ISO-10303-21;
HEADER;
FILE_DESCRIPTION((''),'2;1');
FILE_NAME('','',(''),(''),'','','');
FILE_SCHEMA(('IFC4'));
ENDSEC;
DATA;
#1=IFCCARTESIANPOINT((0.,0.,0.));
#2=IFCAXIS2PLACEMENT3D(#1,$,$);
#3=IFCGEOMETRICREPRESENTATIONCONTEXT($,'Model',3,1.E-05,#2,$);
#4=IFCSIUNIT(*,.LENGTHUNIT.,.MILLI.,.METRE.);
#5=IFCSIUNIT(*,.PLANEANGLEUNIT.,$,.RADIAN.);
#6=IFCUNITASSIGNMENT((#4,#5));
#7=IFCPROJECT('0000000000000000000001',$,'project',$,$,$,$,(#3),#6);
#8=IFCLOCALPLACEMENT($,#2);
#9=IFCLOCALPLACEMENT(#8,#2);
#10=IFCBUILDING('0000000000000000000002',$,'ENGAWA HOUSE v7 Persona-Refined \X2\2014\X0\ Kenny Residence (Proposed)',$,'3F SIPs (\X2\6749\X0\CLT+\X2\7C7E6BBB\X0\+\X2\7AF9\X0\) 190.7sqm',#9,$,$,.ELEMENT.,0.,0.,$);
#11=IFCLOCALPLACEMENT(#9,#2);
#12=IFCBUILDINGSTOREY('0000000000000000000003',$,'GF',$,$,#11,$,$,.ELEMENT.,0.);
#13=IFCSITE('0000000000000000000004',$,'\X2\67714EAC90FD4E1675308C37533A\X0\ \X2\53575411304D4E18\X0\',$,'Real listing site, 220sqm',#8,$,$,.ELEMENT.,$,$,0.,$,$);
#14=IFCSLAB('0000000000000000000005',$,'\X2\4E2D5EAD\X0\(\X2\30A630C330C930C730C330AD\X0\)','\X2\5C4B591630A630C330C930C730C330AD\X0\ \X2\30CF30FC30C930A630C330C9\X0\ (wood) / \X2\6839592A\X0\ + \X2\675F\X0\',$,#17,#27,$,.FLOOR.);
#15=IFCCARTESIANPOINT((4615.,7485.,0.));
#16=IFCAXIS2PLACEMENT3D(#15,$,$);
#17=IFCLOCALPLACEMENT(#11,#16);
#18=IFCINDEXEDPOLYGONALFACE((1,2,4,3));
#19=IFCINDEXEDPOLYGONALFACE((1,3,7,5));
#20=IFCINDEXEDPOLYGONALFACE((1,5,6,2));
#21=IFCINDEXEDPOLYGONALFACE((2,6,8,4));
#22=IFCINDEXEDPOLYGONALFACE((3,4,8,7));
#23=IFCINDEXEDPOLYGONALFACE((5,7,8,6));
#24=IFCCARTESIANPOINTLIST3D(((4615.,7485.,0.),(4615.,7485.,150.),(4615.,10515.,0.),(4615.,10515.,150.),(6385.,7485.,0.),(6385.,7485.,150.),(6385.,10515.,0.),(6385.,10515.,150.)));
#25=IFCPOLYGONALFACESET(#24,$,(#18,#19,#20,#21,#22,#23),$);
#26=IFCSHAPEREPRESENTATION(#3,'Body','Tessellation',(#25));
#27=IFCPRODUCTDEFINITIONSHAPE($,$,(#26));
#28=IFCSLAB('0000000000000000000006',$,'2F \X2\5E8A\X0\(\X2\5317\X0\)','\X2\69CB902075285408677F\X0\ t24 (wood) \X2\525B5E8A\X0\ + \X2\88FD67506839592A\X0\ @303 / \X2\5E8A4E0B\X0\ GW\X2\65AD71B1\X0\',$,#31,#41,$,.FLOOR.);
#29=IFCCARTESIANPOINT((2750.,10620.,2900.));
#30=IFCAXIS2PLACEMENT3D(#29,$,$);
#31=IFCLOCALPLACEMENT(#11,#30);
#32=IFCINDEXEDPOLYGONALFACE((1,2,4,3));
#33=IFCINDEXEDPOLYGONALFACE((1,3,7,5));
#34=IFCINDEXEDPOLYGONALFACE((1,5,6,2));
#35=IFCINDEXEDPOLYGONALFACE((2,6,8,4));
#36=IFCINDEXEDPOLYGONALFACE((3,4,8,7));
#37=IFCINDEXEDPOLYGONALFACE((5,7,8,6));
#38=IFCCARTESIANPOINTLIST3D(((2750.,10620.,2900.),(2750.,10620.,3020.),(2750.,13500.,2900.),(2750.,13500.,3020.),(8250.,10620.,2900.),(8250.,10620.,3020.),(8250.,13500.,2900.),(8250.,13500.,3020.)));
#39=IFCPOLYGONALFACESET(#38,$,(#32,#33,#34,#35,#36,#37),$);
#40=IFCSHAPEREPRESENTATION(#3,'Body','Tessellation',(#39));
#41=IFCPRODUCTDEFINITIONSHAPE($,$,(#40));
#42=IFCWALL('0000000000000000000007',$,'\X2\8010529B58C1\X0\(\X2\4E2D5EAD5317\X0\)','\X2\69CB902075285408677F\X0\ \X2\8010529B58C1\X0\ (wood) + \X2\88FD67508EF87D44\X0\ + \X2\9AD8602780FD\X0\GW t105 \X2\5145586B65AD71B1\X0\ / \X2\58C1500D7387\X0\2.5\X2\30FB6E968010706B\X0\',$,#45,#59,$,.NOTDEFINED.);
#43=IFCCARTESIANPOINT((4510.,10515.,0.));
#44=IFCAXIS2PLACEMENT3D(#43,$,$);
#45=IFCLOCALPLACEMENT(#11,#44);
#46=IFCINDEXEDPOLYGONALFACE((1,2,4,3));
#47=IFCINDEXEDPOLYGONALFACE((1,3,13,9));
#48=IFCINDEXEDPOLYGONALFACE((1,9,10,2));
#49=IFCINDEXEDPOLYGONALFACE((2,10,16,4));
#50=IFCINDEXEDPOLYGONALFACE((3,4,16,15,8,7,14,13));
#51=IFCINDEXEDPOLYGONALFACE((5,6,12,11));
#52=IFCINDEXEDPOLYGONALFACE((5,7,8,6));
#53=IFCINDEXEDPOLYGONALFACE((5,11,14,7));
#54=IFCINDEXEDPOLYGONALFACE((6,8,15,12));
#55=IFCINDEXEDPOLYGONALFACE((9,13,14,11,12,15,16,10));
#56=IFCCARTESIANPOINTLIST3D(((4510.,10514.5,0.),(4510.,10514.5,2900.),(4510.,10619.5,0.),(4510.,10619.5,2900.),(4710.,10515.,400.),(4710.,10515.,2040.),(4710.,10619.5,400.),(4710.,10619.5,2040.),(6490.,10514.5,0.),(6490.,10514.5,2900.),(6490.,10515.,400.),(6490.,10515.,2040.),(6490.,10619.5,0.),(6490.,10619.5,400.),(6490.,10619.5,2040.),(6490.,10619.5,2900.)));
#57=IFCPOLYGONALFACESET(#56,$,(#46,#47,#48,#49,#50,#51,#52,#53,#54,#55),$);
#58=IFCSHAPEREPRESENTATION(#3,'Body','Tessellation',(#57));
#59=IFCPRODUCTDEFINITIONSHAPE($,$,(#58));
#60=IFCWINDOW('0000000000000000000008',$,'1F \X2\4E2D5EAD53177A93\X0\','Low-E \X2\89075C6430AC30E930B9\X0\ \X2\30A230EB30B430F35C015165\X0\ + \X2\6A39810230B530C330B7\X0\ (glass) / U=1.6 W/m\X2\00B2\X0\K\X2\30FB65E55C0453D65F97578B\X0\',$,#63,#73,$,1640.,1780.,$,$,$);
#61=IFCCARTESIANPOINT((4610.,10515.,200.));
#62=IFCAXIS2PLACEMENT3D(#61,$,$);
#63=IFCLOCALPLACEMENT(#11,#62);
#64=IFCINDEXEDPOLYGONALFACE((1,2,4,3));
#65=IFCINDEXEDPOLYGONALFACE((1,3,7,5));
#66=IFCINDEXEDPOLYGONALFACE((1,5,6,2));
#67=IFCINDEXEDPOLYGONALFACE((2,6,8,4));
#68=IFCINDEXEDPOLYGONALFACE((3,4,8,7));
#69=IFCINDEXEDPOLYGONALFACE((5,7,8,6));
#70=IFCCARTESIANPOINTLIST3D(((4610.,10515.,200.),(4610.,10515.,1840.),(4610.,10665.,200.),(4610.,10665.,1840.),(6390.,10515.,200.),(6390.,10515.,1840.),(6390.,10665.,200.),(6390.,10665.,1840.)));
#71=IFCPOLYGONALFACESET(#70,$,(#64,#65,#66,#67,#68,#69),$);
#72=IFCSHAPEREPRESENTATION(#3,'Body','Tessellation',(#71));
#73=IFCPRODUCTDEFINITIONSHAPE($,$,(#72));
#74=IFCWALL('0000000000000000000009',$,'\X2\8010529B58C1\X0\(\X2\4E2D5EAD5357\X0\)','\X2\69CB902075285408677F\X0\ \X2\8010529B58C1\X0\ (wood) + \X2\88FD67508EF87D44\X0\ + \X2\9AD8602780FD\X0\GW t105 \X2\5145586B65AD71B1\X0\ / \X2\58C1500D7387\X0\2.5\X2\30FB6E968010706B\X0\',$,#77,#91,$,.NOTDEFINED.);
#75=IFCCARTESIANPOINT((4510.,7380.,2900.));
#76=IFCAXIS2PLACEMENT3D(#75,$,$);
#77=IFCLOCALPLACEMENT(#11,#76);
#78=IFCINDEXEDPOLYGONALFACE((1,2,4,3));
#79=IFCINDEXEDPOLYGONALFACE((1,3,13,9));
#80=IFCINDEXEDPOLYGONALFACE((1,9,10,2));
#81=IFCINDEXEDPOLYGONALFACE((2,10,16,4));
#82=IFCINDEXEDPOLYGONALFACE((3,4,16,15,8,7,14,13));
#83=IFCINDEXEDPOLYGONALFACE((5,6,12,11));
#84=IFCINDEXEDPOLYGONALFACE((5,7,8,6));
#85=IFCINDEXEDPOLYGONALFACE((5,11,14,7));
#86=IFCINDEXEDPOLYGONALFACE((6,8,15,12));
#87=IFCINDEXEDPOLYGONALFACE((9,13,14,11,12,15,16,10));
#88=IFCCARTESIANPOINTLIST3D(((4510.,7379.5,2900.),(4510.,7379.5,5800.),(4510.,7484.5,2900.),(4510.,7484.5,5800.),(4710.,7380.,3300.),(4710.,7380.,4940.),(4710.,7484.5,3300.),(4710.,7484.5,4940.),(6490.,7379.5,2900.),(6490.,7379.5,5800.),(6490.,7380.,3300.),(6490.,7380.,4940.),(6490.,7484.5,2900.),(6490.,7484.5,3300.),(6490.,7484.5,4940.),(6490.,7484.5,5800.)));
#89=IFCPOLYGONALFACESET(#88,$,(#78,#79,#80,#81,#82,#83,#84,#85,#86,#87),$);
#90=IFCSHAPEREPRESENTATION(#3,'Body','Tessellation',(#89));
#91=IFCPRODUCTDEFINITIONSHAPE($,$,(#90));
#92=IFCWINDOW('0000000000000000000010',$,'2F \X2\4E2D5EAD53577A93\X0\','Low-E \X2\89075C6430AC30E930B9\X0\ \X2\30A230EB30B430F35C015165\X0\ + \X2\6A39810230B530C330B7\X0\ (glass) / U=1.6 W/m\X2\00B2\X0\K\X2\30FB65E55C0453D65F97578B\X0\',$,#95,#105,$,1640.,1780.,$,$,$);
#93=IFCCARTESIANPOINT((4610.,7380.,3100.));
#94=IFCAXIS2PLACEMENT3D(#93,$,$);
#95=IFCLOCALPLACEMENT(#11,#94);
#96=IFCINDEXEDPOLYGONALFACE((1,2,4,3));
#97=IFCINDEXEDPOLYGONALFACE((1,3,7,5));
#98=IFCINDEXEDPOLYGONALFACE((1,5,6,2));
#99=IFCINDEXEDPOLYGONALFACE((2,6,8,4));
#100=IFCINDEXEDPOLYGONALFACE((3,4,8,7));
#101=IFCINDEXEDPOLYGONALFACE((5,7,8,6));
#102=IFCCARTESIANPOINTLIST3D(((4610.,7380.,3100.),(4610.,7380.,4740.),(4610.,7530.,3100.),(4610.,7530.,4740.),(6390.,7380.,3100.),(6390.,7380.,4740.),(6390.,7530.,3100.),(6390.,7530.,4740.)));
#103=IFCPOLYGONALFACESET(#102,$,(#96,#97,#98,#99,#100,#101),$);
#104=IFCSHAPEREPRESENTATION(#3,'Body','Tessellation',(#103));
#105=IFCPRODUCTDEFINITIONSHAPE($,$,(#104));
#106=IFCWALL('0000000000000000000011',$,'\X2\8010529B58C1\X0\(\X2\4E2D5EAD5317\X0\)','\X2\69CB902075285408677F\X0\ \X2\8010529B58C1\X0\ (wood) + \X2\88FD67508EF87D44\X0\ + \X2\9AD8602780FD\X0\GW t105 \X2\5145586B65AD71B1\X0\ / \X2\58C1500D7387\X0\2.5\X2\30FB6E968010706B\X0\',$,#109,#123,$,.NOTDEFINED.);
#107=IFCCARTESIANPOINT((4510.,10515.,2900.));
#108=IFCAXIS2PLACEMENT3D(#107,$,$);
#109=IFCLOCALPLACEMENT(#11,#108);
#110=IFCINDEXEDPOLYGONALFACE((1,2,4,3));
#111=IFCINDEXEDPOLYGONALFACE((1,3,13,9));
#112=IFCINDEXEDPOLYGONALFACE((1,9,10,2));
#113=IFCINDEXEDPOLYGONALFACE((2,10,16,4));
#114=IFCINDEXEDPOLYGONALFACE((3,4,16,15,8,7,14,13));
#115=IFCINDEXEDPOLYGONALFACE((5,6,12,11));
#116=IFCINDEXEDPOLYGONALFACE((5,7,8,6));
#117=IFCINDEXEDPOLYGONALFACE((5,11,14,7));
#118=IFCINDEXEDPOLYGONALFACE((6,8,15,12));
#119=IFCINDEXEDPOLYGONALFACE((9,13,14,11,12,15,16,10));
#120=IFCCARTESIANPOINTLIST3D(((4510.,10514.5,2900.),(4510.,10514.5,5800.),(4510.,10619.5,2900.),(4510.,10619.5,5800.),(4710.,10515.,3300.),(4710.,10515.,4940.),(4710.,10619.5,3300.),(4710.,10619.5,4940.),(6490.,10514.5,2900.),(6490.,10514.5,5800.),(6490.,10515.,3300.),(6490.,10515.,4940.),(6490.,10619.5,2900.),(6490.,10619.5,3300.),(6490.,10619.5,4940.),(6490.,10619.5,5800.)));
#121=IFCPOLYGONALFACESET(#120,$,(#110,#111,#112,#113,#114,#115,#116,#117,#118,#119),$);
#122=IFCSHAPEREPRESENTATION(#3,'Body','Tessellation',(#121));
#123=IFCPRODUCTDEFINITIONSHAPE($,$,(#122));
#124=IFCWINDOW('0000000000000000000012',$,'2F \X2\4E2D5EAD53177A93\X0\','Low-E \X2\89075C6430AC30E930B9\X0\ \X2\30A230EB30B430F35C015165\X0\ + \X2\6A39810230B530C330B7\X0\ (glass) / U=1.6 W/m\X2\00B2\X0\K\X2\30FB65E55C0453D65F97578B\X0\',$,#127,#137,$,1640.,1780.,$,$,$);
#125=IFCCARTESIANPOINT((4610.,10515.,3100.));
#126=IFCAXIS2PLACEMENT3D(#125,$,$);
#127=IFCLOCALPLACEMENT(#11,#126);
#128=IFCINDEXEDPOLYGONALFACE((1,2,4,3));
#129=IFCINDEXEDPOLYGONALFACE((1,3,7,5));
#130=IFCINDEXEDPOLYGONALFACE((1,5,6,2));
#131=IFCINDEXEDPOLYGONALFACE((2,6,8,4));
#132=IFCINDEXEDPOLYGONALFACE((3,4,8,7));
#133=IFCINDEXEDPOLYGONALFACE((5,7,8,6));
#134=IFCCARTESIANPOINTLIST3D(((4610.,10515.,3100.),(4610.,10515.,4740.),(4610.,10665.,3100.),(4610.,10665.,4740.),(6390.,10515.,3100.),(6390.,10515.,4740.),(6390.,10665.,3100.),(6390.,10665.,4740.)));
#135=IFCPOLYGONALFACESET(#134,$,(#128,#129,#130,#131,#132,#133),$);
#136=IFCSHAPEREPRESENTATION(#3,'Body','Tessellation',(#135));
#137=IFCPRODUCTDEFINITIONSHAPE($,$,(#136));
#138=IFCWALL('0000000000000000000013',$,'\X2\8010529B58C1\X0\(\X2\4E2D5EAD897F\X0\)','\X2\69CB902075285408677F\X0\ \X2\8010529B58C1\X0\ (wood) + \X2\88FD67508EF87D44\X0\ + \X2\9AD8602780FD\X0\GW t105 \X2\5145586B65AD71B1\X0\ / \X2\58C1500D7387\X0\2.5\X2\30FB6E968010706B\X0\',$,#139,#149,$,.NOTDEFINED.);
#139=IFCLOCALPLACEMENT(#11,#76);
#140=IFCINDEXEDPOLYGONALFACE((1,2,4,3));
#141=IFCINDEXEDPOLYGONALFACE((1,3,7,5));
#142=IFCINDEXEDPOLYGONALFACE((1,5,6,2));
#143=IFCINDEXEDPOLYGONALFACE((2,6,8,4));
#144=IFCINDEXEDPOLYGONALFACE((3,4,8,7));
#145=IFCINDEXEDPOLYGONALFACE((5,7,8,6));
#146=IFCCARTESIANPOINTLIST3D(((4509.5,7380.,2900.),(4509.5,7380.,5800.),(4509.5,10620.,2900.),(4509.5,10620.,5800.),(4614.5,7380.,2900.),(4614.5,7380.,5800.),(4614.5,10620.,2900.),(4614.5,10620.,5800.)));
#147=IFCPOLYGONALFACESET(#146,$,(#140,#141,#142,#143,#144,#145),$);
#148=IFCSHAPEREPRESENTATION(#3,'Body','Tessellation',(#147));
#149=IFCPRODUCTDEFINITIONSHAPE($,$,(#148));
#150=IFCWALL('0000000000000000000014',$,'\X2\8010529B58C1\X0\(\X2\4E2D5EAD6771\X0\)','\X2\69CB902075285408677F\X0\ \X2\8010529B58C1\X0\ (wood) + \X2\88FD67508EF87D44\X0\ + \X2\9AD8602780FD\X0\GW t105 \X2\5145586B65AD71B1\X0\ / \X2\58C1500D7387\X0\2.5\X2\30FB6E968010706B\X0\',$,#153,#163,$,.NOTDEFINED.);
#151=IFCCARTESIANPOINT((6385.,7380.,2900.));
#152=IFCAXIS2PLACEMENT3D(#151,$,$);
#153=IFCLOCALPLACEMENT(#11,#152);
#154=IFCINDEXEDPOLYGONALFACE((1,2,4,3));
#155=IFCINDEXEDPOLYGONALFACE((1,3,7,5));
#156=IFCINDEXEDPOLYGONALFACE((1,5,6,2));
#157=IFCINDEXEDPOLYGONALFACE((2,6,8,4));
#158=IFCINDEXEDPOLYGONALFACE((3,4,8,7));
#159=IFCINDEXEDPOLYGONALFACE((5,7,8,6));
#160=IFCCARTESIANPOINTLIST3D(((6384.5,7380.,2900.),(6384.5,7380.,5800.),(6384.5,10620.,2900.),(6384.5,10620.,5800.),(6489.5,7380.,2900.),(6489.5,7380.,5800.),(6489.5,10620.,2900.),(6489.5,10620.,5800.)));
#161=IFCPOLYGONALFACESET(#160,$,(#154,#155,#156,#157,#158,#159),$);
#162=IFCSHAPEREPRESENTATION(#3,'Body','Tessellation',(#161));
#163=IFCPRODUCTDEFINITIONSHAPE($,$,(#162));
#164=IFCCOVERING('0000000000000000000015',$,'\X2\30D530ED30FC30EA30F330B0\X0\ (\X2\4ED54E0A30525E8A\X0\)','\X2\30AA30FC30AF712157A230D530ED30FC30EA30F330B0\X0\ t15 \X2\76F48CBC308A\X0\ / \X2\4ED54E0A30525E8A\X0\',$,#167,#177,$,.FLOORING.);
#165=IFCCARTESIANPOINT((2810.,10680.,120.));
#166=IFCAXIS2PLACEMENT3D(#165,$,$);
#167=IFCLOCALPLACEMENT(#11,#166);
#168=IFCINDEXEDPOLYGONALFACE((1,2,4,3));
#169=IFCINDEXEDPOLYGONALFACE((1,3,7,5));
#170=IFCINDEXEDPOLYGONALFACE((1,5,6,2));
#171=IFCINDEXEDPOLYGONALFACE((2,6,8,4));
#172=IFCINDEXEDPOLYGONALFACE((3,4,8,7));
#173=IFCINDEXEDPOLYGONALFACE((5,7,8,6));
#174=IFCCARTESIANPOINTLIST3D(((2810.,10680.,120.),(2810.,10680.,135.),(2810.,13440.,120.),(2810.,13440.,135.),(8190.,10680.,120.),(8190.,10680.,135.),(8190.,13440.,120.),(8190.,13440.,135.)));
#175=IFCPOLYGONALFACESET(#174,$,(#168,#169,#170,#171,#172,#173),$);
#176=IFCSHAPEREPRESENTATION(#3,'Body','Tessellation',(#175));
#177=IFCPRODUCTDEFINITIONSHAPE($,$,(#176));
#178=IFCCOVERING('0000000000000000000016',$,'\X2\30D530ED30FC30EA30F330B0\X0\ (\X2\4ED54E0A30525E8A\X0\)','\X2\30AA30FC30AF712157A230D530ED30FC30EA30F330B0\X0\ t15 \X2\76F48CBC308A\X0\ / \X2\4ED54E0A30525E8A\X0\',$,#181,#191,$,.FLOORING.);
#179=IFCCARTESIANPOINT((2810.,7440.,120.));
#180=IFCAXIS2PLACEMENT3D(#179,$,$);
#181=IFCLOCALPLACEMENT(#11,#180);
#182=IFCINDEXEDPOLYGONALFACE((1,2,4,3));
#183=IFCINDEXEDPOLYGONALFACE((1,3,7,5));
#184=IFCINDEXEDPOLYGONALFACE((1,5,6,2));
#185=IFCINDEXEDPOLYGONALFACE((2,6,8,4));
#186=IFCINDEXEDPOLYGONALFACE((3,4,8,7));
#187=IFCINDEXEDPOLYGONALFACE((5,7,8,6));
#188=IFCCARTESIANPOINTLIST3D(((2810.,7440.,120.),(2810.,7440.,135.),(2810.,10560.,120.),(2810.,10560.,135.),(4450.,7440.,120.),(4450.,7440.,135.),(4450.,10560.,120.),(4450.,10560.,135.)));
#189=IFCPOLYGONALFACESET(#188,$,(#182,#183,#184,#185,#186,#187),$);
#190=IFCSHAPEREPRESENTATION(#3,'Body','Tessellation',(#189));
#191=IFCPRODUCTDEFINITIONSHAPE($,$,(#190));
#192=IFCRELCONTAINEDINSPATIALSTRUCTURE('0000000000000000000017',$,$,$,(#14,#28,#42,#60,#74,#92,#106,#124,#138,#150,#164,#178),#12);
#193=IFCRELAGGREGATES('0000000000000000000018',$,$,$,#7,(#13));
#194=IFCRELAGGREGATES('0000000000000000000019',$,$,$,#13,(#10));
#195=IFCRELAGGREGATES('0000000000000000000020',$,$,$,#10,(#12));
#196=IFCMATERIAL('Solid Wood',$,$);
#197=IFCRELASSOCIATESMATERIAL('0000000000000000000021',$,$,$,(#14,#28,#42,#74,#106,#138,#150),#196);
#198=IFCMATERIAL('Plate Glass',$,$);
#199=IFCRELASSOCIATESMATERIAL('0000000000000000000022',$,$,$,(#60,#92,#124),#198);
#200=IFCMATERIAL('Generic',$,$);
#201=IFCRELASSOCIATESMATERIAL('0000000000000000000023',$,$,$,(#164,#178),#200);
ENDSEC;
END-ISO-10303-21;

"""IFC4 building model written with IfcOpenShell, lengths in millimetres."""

from ifc_helpers import new_model, si_unit, frame, frame_2d, origin, place, context, project, spatial, rectangle, extrude, material, element, fill, save


model = new_model("IFC4")

# Units and contexts
model_context = context("Model", 3, precision=1e-05, world=origin())
ifc_project = project(units=[si_unit("LENGTHUNIT", "METRE", prefix="MILLI"), si_unit("PLANEANGLEUNIT", "RADIAN")], contexts=[model_context])

# Site, building, storey
site_placement = place(None, origin())
site = spatial("IfcSite", under=ifc_project, at=site_placement, Name="東京都世田谷区 南向き丘", ObjectType="Real listing site, 220sqm", CompositionType="ELEMENT", RefElevation=0.0)
building_placement = place(site_placement, origin())
building = spatial("IfcBuilding", under=site, at=building_placement, Name="ENGAWA HOUSE v7 Persona-Refined — Kenny Residence (Proposed)", ObjectType="3F SIPs (杉CLT+籾殻+竹) 190.7sqm", CompositionType="ELEMENT", ElevationOfRefHeight=0.0, ElevationOfTerrain=0.0)
storey_placement = place(building_placement, origin())
storey = spatial("IfcBuildingStorey", under=building, at=storey_placement, Name="GF", CompositionType="ELEMENT", Elevation=0.0)

# Slabs
ifc_material_1 = material(Name="Solid Wood")
slab_1_placement = place(storey_placement, frame((4615.0, 7485.0, 0.0)))
element("IfcSlab", 1, at=slab_1_placement, inside=storey, material=ifc_material_1, Name="中庭(ウッドデッキ)", Description="屋外ウッドデッキ ハードウッド (wood) / 根太 + 束", PredefinedType="FLOOR", context=model_context, shape_type="SweptSolid", body=[
    extrude(rectangle(XDim=1770.0, YDim=3030.0, at=frame_2d((885.0, 1515.0))), frame((4615.0, 7485.0, 0.0)), (0.0, 0.0, 1.0), 150.0),
])
slab_2_placement = place(storey_placement, frame((2750.0, 10620.0, 2900.0)))
element("IfcSlab", 2, at=slab_2_placement, inside=storey, material=ifc_material_1, Name="2F 床(北)", Description="構造用合板 t24 (wood) 剛床 + 製材根太 @303 / 床下 GW断熱", PredefinedType="FLOOR", context=model_context, shape_type="SweptSolid", body=[
    extrude(rectangle(XDim=5500.0, YDim=2880.0, at=frame_2d((2750.0, 1440.0))), frame((2750.0, 10620.0, 2900.0)), (0.0, 0.0, 1.0), 120.0),
])

# Wall, opening, window
wall_1_placement = place(storey_placement, frame((4510.0, 10515.0, 0.0)))
wall_1 = element("IfcWall", 3, at=wall_1_placement, inside=storey, material=ifc_material_1, Name="耐力壁(中庭北)", Description="構造用合板 耐力壁 (wood) + 製材軸組 + 高性能GW t105 充填断熱 / 壁倍率2.5・準耐火", PredefinedType="NOTDEFINED", context=model_context, shape_type="SweptSolid", body=[
    extrude(rectangle(XDim=1980.0, YDim=105.0, at=frame_2d((990.0, 52.0))), frame((4510.0, 10515.0, 0.0)), (0.0, 0.0, 1.0), 2900.0),
])
opening_1_placement = place(storey_placement, frame((4610.0, 10515.0, 200.0)))
opening_1 = element("IfcOpeningElement", 4, at=opening_1_placement, cuts=wall_1, PredefinedType="NOTDEFINED", context=model_context, shape_type="SweptSolid", body=[
    extrude(rectangle(XDim=1780.0, YDim=150.0, at=frame_2d((890.0, 75.0))), frame((4610.0, 10515.0, 200.0)), (0.0, 0.0, 1.0), 1640.0),
])
ifc_material_2 = material(Name="Plate Glass")
window_1_placement = place(storey_placement, frame((4610.0, 10515.0, 200.0)))
window_1 = element("IfcWindow", 5, at=window_1_placement, inside=storey, material=ifc_material_2, Name="1F 中庭北窓", Description="Low-E 複層ガラス アルゴン封入 + 樹脂サッシ (glass) / U=1.6 W/m²K・日射取得型", OverallHeight=1640.0, OverallWidth=1780.0, context=model_context, shape_type="SweptSolid", body=[
    extrude(rectangle(XDim=1780.0, YDim=150.0, at=frame_2d((890.0, 75.0))), frame((4610.0, 10515.0, 200.0)), (0.0, 0.0, 1.0), 1640.0),
])
fill(opening_1, window_1)

# Walls, openings, windows
wall_2_placement = place(storey_placement, frame((4510.0, 7380.0, 2900.0)))
wall_2 = element("IfcWall", 6, at=wall_2_placement, inside=storey, material=ifc_material_1, Name="耐力壁(中庭南)", Description="構造用合板 耐力壁 (wood) + 製材軸組 + 高性能GW t105 充填断熱 / 壁倍率2.5・準耐火", PredefinedType="NOTDEFINED", context=model_context, shape_type="SweptSolid", body=[
    extrude(rectangle(XDim=1980.0, YDim=105.0, at=frame_2d((990.0, 52.0))), frame((4510.0, 7380.0, 2900.0)), (0.0, 0.0, 1.0), 2900.0),
])
opening_2_placement = place(storey_placement, frame((4610.0, 7380.0, 3100.0)))
opening_2 = element("IfcOpeningElement", 7, at=opening_2_placement, cuts=wall_2, PredefinedType="NOTDEFINED", context=model_context, shape_type="SweptSolid", body=[
    extrude(rectangle(XDim=1780.0, YDim=150.0, at=frame_2d((890.0, 75.0))), frame((4610.0, 7380.0, 3100.0)), (0.0, 0.0, 1.0), 1640.0),
])
window_2_placement = place(storey_placement, frame((4610.0, 7380.0, 3100.0)))
window_2 = element("IfcWindow", 8, at=window_2_placement, inside=storey, material=ifc_material_2, Name="2F 中庭南窓", Description="Low-E 複層ガラス アルゴン封入 + 樹脂サッシ (glass) / U=1.6 W/m²K・日射取得型", OverallHeight=1640.0, OverallWidth=1780.0, context=model_context, shape_type="SweptSolid", body=[
    extrude(rectangle(XDim=1780.0, YDim=150.0, at=frame_2d((890.0, 75.0))), frame((4610.0, 7380.0, 3100.0)), (0.0, 0.0, 1.0), 1640.0),
])
fill(opening_2, window_2)
wall_3_placement = place(storey_placement, frame((4510.0, 10515.0, 2900.0)))
wall_3 = element("IfcWall", 9, at=wall_3_placement, inside=storey, material=ifc_material_1, Name="耐力壁(中庭北)", Description="構造用合板 耐力壁 (wood) + 製材軸組 + 高性能GW t105 充填断熱 / 壁倍率2.5・準耐火", PredefinedType="NOTDEFINED", context=model_context, shape_type="SweptSolid", body=[
    extrude(rectangle(XDim=1980.0, YDim=105.0, at=frame_2d((990.0, 52.0))), frame((4510.0, 10515.0, 2900.0)), (0.0, 0.0, 1.0), 2900.0),
])
opening_3_placement = place(storey_placement, frame((4610.0, 10515.0, 3100.0)))
opening_3 = element("IfcOpeningElement", 10, at=opening_3_placement, cuts=wall_3, PredefinedType="NOTDEFINED", context=model_context, shape_type="SweptSolid", body=[
    extrude(rectangle(XDim=1780.0, YDim=150.0, at=frame_2d((890.0, 75.0))), frame((4610.0, 10515.0, 3100.0)), (0.0, 0.0, 1.0), 1640.0),
])
window_3_placement = place(storey_placement, frame((4610.0, 10515.0, 3100.0)))
window_3 = element("IfcWindow", 11, at=window_3_placement, inside=storey, material=ifc_material_2, Name="2F 中庭北窓", Description="Low-E 複層ガラス アルゴン封入 + 樹脂サッシ (glass) / U=1.6 W/m²K・日射取得型", OverallHeight=1640.0, OverallWidth=1780.0, context=model_context, shape_type="SweptSolid", body=[
    extrude(rectangle(XDim=1780.0, YDim=150.0, at=frame_2d((890.0, 75.0))), frame((4610.0, 10515.0, 3100.0)), (0.0, 0.0, 1.0), 1640.0),
])
fill(opening_3, window_3)

# Walls
wall_4_placement = place(storey_placement, frame((4510.0, 7380.0, 2900.0)))
element("IfcWall", 12, at=wall_4_placement, inside=storey, material=ifc_material_1, Name="耐力壁(中庭西)", Description="構造用合板 耐力壁 (wood) + 製材軸組 + 高性能GW t105 充填断熱 / 壁倍率2.5・準耐火", PredefinedType="NOTDEFINED", context=model_context, shape_type="SweptSolid", body=[
    extrude(rectangle(XDim=105.0, YDim=3240.0, at=frame_2d((52.0, 1620.0))), frame((4510.0, 7380.0, 2900.0)), (0.0, 0.0, 1.0), 2900.0),
])
wall_5_placement = place(storey_placement, frame((6385.0, 7380.0, 2900.0)))
element("IfcWall", 13, at=wall_5_placement, inside=storey, material=ifc_material_1, Name="耐力壁(中庭東)", Description="構造用合板 耐力壁 (wood) + 製材軸組 + 高性能GW t105 充填断熱 / 壁倍率2.5・準耐火", PredefinedType="NOTDEFINED", context=model_context, shape_type="SweptSolid", body=[
    extrude(rectangle(XDim=105.0, YDim=3240.0, at=frame_2d((52.0, 1620.0))), frame((6385.0, 7380.0, 2900.0)), (0.0, 0.0, 1.0), 2900.0),
])

# Coverings
ifc_material_3 = material(Name="Generic")
covering_1_placement = place(storey_placement, frame((2810.0, 10680.0, 120.0)))
element("IfcCovering", 14, at=covering_1_placement, inside=storey, material=ifc_material_3, Name="フローリング (仕上げ床)", Description="オーク無垢フローリング t15 直貼り / 仕上げ床", PredefinedType="FLOORING", context=model_context, shape_type="SweptSolid", body=[
    extrude(rectangle(XDim=5380.0, YDim=2760.0, at=frame_2d((2690.0, 1380.0))), frame((2810.0, 10680.0, 120.0)), (0.0, 0.0, 1.0), 15.0),
])
covering_2_placement = place(storey_placement, frame((2810.0, 7440.0, 120.0)))
element("IfcCovering", 15, at=covering_2_placement, inside=storey, material=ifc_material_3, Name="フローリング (仕上げ床)", Description="オーク無垢フローリング t15 直貼り / 仕上げ床", PredefinedType="FLOORING", context=model_context, shape_type="SweptSolid", body=[
    extrude(rectangle(XDim=1640.0, YDim=3120.0, at=frame_2d((820.0, 1560.0))), frame((2810.0, 7440.0, 120.0)), (0.0, 0.0, 1.0), 15.0),
])

save(model, "model.ifc")
